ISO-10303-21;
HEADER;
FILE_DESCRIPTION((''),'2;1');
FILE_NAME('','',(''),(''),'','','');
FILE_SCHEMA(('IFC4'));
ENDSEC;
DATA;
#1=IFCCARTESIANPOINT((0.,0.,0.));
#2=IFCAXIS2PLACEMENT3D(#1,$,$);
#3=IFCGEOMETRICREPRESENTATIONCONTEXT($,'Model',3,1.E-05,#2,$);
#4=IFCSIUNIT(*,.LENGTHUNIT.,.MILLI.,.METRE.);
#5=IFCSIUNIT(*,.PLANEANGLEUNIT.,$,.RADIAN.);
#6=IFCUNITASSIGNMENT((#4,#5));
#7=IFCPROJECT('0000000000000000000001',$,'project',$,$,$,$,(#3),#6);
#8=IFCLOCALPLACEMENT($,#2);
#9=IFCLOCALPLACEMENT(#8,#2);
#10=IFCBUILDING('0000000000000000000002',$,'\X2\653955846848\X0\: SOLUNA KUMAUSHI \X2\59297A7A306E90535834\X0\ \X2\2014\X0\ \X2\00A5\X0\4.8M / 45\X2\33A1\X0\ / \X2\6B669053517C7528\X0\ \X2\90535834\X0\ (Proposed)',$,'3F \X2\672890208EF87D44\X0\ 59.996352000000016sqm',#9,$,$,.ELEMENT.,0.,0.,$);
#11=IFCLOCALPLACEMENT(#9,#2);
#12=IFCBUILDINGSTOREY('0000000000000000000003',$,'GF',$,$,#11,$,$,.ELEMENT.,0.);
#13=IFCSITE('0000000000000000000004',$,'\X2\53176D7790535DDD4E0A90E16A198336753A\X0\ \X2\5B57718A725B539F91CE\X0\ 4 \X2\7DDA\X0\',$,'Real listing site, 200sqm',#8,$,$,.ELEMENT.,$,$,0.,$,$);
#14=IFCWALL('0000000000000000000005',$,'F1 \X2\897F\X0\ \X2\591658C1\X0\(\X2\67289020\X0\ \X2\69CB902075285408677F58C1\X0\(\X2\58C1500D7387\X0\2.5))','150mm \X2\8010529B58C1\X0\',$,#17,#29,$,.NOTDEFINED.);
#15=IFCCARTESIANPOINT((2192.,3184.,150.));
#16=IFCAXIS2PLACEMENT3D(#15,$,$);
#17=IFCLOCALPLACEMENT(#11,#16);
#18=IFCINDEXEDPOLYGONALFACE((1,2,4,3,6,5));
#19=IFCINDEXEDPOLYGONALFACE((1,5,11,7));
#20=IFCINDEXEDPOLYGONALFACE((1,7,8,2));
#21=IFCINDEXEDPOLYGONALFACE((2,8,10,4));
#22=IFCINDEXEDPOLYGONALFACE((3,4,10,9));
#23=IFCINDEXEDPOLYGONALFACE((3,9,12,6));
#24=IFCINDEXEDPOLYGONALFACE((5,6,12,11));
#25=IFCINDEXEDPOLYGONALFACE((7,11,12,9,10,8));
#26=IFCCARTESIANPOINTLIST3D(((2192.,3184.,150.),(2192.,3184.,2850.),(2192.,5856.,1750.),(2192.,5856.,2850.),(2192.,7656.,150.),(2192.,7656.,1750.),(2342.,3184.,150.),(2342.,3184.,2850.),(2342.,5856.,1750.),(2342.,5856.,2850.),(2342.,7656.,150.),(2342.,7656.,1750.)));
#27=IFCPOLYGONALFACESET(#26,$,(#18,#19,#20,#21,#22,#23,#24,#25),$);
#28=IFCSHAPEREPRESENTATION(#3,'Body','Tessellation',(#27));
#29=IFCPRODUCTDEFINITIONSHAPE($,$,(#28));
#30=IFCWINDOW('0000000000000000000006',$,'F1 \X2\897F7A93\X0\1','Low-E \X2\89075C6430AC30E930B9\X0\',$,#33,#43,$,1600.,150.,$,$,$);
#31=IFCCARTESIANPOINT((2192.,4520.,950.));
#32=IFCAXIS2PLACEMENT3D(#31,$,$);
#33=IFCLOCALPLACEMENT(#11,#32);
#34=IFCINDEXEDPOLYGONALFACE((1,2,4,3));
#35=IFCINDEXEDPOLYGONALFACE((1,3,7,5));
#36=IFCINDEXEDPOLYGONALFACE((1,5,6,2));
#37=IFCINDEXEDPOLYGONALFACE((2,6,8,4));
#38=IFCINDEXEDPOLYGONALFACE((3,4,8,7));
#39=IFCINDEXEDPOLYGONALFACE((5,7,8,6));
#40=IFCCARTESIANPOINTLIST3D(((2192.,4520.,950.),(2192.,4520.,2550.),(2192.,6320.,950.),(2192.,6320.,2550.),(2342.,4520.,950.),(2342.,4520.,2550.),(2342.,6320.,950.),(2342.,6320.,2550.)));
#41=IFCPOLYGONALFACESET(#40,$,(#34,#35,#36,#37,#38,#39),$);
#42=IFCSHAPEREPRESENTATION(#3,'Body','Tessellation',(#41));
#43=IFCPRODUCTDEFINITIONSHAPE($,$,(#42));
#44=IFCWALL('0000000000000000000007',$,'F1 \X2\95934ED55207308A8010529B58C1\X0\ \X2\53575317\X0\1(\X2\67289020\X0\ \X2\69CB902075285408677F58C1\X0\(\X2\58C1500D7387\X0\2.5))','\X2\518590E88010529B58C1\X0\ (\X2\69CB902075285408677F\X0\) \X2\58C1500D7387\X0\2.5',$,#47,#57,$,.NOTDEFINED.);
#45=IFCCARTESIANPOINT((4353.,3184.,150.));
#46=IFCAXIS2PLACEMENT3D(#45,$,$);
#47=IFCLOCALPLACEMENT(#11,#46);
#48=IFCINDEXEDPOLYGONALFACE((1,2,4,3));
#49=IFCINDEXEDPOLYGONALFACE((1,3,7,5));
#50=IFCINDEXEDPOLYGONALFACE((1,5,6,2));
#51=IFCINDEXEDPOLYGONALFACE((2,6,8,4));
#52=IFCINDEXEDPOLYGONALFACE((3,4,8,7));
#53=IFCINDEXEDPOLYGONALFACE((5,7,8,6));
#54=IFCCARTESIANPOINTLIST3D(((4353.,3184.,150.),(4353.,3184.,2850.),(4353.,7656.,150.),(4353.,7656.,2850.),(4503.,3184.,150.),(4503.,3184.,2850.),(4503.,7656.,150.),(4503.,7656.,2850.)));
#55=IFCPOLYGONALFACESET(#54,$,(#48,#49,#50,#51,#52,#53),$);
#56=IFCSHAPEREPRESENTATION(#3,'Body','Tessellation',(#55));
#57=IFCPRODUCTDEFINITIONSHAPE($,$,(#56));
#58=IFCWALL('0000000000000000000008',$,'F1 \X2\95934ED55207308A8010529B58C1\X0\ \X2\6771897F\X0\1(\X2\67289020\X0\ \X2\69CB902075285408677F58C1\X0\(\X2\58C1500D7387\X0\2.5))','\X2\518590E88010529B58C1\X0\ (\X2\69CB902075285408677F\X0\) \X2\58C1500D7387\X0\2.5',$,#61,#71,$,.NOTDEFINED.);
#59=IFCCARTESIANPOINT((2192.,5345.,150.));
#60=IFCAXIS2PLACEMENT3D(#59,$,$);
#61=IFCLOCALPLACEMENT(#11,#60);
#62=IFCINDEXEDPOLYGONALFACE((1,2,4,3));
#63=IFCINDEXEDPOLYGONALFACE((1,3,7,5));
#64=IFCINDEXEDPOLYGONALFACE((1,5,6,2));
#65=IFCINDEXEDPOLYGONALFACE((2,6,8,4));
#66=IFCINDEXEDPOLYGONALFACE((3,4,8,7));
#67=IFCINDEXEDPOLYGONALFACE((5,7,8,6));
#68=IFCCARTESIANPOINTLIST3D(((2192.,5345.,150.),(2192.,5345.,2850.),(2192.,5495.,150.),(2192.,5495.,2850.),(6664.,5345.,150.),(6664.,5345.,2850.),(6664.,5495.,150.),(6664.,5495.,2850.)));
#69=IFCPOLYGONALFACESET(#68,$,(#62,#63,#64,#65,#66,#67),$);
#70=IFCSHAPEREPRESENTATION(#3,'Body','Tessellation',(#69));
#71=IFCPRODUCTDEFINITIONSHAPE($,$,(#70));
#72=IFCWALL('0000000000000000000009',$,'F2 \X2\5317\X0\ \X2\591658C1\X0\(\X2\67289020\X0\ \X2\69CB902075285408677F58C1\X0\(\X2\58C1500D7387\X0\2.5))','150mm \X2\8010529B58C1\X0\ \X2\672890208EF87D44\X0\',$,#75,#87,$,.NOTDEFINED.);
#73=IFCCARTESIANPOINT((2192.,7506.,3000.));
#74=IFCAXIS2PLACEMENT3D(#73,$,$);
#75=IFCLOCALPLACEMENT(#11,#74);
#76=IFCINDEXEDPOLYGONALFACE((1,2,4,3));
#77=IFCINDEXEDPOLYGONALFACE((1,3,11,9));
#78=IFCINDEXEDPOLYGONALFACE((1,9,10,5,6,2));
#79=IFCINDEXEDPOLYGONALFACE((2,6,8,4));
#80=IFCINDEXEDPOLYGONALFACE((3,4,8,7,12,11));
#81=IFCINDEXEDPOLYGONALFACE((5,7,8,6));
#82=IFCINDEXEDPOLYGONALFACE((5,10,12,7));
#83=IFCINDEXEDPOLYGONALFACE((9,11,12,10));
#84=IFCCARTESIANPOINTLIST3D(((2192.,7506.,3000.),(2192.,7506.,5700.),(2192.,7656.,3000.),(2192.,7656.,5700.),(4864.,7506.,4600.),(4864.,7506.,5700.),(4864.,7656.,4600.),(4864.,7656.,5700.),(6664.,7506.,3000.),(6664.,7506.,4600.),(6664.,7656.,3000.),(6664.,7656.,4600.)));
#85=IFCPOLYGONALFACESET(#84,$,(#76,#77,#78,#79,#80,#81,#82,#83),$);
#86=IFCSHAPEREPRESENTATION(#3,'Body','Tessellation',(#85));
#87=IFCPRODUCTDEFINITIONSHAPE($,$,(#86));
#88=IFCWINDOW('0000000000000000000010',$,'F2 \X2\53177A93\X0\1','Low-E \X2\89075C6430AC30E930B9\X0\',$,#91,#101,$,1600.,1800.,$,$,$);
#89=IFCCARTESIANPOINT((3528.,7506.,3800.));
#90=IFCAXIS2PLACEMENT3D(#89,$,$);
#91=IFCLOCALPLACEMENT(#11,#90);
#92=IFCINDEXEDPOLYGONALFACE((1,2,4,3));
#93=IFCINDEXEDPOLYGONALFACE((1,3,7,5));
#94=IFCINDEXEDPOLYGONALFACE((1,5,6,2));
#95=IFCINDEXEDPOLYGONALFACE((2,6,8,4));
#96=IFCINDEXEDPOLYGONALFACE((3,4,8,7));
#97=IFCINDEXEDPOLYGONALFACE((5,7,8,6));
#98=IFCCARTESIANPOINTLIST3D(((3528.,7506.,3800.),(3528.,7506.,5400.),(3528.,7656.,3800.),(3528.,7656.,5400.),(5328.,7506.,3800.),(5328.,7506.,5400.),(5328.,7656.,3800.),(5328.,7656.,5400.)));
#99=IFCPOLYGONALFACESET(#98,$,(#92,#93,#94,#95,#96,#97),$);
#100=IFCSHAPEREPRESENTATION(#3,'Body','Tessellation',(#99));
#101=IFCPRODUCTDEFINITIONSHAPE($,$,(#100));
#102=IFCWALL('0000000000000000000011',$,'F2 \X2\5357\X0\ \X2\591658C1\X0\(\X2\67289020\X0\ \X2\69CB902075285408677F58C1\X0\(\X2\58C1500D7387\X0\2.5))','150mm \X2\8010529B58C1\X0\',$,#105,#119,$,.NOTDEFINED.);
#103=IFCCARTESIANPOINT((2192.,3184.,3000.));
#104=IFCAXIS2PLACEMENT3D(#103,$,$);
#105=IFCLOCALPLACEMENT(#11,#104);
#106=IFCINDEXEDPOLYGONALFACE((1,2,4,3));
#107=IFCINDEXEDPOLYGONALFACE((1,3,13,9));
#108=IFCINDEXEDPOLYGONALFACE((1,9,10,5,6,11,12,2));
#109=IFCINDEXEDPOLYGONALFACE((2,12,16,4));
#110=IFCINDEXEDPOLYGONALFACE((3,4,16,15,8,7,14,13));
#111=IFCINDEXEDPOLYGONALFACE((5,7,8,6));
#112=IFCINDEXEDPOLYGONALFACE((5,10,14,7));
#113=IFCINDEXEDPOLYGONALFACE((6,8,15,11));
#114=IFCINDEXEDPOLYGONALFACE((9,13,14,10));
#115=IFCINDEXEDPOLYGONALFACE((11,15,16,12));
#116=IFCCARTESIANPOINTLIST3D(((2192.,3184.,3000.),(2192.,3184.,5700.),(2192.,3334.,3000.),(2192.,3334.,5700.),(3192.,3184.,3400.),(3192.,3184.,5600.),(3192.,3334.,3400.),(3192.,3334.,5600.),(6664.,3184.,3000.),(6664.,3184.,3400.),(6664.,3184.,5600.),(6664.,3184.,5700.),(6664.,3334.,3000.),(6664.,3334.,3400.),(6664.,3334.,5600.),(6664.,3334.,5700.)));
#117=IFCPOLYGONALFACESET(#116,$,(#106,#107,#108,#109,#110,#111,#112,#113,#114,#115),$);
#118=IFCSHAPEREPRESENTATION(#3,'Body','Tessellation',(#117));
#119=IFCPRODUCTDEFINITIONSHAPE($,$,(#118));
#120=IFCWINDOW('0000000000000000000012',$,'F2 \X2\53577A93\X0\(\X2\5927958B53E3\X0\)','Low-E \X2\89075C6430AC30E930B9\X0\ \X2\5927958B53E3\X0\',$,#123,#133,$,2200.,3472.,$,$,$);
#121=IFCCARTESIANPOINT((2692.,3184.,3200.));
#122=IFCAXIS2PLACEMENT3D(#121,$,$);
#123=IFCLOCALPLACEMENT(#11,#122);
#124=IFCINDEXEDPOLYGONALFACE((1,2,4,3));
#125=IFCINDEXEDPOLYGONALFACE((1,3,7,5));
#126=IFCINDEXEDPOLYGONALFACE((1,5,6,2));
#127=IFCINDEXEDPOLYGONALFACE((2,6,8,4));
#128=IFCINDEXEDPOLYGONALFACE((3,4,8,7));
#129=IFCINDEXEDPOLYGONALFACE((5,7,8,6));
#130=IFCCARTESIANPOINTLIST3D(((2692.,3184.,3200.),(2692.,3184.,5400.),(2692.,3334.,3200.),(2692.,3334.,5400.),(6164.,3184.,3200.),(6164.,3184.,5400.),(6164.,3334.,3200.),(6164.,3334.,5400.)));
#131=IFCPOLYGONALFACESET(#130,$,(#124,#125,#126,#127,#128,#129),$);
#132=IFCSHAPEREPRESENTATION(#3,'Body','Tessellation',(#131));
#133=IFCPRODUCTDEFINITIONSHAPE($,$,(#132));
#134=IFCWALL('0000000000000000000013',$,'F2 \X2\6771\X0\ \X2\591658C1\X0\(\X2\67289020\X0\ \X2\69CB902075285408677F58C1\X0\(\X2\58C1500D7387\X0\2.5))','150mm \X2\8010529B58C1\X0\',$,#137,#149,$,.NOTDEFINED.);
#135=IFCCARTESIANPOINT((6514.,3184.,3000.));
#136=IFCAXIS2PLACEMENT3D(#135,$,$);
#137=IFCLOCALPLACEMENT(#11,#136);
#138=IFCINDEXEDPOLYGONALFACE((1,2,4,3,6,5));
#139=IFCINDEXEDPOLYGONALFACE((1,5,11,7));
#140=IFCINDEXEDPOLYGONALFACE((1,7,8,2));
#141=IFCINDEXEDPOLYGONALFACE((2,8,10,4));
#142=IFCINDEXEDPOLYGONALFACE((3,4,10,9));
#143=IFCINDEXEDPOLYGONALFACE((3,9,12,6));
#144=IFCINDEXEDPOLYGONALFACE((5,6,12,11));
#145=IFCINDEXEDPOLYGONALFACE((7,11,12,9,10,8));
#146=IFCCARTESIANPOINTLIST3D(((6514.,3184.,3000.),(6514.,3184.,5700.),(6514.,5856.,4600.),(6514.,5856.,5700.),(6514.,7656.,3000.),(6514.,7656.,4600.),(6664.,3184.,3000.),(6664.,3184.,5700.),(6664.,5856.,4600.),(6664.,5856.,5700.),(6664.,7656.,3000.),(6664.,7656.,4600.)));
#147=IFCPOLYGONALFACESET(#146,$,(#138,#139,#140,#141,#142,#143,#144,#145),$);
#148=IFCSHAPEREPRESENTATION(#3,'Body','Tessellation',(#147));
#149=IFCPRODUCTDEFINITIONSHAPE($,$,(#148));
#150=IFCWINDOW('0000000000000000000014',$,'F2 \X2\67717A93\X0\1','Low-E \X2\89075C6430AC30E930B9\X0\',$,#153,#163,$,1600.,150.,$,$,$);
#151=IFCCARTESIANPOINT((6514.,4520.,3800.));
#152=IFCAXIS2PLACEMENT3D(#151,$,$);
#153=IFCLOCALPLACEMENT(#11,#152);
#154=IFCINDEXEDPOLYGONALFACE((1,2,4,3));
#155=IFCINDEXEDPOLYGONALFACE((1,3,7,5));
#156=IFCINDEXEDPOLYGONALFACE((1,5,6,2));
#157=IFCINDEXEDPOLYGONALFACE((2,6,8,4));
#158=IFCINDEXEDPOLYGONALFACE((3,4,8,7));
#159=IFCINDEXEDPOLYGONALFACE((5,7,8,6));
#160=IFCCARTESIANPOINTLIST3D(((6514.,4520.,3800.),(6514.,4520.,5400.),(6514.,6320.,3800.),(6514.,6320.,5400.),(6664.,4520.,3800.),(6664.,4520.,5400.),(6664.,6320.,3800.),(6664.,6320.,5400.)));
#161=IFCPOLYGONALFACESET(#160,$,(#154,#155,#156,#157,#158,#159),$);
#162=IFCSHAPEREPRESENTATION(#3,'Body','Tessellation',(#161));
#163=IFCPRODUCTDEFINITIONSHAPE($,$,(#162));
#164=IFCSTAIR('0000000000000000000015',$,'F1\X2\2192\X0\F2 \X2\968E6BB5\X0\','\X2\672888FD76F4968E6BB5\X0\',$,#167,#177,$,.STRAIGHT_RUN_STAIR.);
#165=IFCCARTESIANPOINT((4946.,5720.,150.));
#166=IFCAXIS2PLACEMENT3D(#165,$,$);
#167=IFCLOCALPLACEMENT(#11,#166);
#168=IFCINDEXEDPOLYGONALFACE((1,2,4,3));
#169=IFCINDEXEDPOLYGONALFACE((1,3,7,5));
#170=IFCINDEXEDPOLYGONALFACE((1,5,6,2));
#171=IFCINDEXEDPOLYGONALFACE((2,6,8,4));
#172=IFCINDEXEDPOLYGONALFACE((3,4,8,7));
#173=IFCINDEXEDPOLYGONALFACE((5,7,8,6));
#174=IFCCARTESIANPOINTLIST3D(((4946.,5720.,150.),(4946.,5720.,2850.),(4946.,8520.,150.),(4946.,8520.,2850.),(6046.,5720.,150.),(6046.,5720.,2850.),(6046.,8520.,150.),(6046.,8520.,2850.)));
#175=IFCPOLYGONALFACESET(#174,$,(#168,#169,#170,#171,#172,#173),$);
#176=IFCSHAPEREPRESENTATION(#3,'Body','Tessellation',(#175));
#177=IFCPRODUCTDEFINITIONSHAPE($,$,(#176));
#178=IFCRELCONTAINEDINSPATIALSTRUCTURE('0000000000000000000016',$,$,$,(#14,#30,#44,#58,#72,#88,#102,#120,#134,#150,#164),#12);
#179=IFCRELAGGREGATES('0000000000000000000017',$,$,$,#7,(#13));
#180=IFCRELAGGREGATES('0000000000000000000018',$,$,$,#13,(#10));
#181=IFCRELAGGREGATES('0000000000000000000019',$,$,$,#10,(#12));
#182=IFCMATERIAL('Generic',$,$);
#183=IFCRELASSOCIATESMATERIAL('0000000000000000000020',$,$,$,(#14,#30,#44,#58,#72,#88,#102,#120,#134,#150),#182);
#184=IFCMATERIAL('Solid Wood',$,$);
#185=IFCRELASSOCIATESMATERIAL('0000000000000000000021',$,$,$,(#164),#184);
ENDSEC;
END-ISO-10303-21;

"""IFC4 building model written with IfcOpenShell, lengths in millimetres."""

from ifc_helpers import new_model, si_unit, frame, frame_2d, origin, place, context, project, spatial, rectangle, extrude, material, element, fill, save


model = new_model("IFC4")

# Units and contexts
model_context = context("Model", 3, precision=1e-05, world=origin())
ifc_project = project(units=[si_unit("LENGTHUNIT", "METRE", prefix="MILLI"), si_unit("PLANEANGLEUNIT", "RADIAN")], contexts=[model_context])

# Site, building, storey
site_placement = place(None, origin())
site = spatial("IfcSite", under=ifc_project, at=site_placement, Name="北海道川上郡標茶町 字熊牛原野 4 線", ObjectType="Real listing site, 200sqm", CompositionType="ELEMENT", RefElevation=0.0)
building_placement = place(site_placement, origin())
building = spatial("IfcBuilding", under=site, at=building_placement, Name="改善案: SOLUNA KUMAUSHI 天空の道場 — ¥4.8M / 45㎡ / 武道兼用 道場 (Proposed)", ObjectType="3F 木造軸組 59.996352000000016sqm", CompositionType="ELEMENT", ElevationOfRefHeight=0.0, ElevationOfTerrain=0.0)
storey_placement = place(building_placement, origin())
storey = spatial("IfcBuildingStorey", under=building, at=storey_placement, Name="GF", CompositionType="ELEMENT", Elevation=0.0)

# Shared definitions
ifc_material_1 = material(Name="Generic")

# Shared definitions
ifc_material_2 = material(Name="Solid Wood")

# Wall, opening, window
wall_1_placement = place(storey_placement, frame((2192.0, 3184.0, 150.0)))
wall_1 = element("IfcWall", 1, at=wall_1_placement, inside=storey, material=ifc_material_1, Name="F1 西 外壁(木造 構造用合板壁(壁倍率2.5))", Description="150mm 耐力壁", PredefinedType="NOTDEFINED", context=model_context, shape_type="SweptSolid", body=[
    extrude(rectangle(XDim=150.0, YDim=4472.0, at=frame_2d((75.0, 2236.0))), frame((2192.0, 3184.0, 150.0)), (0.0, 0.0, 1.0), 2700.0),
])
opening_1_placement = place(storey_placement, frame((2192.0, 4520.0, 950.0)))
opening_1 = element("IfcOpeningElement", 2, at=opening_1_placement, cuts=wall_1, PredefinedType="NOTDEFINED", context=model_context, shape_type="SweptSolid", body=[
    extrude(rectangle(XDim=150.0, YDim=1800.0, at=frame_2d((75.0, 900.0))), frame((2192.0, 4520.0, 950.0)), (0.0, 0.0, 1.0), 1600.0),
])
window_1_placement = place(storey_placement, frame((2192.0, 4520.0, 950.0)))
window_1 = element("IfcWindow", 3, at=window_1_placement, inside=storey, material=ifc_material_1, Name="F1 西窓1", Description="Low-E 複層ガラス", OverallHeight=1600.0, OverallWidth=150.0, context=model_context, shape_type="SweptSolid", body=[
    extrude(rectangle(XDim=150.0, YDim=1800.0, at=frame_2d((75.0, 900.0))), frame((2192.0, 4520.0, 950.0)), (0.0, 0.0, 1.0), 1600.0),
])
fill(opening_1, window_1)

# Walls
wall_2_placement = place(storey_placement, frame((4353.0, 3184.0, 150.0)))
element("IfcWall", 4, at=wall_2_placement, inside=storey, material=ifc_material_1, Name="F1 間仕切り耐力壁 南北1(木造 構造用合板壁(壁倍率2.5))", Description="内部耐力壁 (構造用合板) 壁倍率2.5", PredefinedType="NOTDEFINED", context=model_context, shape_type="SweptSolid", body=[
    extrude(rectangle(XDim=150.0, YDim=4472.0, at=frame_2d((75.0, 2236.0))), frame((4353.0, 3184.0, 150.0)), (0.0, 0.0, 1.0), 2700.0),
])
wall_3_placement = place(storey_placement, frame((2192.0, 5345.0, 150.0)))
element("IfcWall", 5, at=wall_3_placement, inside=storey, material=ifc_material_1, Name="F1 間仕切り耐力壁 東西1(木造 構造用合板壁(壁倍率2.5))", Description="内部耐力壁 (構造用合板) 壁倍率2.5", PredefinedType="NOTDEFINED", context=model_context, shape_type="SweptSolid", body=[
    extrude(rectangle(XDim=4472.0, YDim=150.0, at=frame_2d((2236.0, 75.0))), frame((2192.0, 5345.0, 150.0)), (0.0, 0.0, 1.0), 2700.0),
])

# Walls, openings, windows
wall_4_placement = place(storey_placement, frame((2192.0, 7506.0, 3000.0)))
wall_4 = element("IfcWall", 6, at=wall_4_placement, inside=storey, material=ifc_material_1, Name="F2 北 外壁(木造 構造用合板壁(壁倍率2.5))", Description="150mm 耐力壁 木造軸組", PredefinedType="NOTDEFINED", context=model_context, shape_type="SweptSolid", body=[
    extrude(rectangle(XDim=4472.0, YDim=150.0, at=frame_2d((2236.0, 75.0))), frame((2192.0, 7506.0, 3000.0)), (0.0, 0.0, 1.0), 2700.0),
])
opening_2_placement = place(storey_placement, frame((3528.0, 7506.0, 3800.0)))
opening_2 = element("IfcOpeningElement", 7, at=opening_2_placement, cuts=wall_4, PredefinedType="NOTDEFINED", context=model_context, shape_type="SweptSolid", body=[
    extrude(rectangle(XDim=1800.0, YDim=150.0, at=frame_2d((900.0, 75.0))), frame((3528.0, 7506.0, 3800.0)), (0.0, 0.0, 1.0), 1600.0),
])
window_2_placement = place(storey_placement, frame((3528.0, 7506.0, 3800.0)))
window_2 = element("IfcWindow", 8, at=window_2_placement, inside=storey, material=ifc_material_1, Name="F2 北窓1", Description="Low-E 複層ガラス", OverallHeight=1600.0, OverallWidth=1800.0, context=model_context, shape_type="SweptSolid", body=[
    extrude(rectangle(XDim=1800.0, YDim=150.0, at=frame_2d((900.0, 75.0))), frame((3528.0, 7506.0, 3800.0)), (0.0, 0.0, 1.0), 1600.0),
])
fill(opening_2, window_2)
wall_5_placement = place(storey_placement, frame((2192.0, 3184.0, 3000.0)))
wall_5 = element("IfcWall", 9, at=wall_5_placement, inside=storey, material=ifc_material_1, Name="F2 南 外壁(木造 構造用合板壁(壁倍率2.5))", Description="150mm 耐力壁", PredefinedType="NOTDEFINED", context=model_context, shape_type="SweptSolid", body=[
    extrude(rectangle(XDim=4472.0, YDim=150.0, at=frame_2d((2236.0, 75.0))), frame((2192.0, 3184.0, 3000.0)), (0.0, 0.0, 1.0), 2700.0),
])
opening_3_placement = place(storey_placement, frame((2692.0, 3184.0, 3200.0)))
opening_3 = element("IfcOpeningElement", 10, at=opening_3_placement, cuts=wall_5, PredefinedType="NOTDEFINED", context=model_context, shape_type="SweptSolid", body=[
    extrude(rectangle(XDim=3472.0, YDim=150.0, at=frame_2d((1736.0, 75.0))), frame((2692.0, 3184.0, 3200.0)), (0.0, 0.0, 1.0), 2200.0),
])
window_3_placement = place(storey_placement, frame((2692.0, 3184.0, 3200.0)))
window_3 = element("IfcWindow", 11, at=window_3_placement, inside=storey, material=ifc_material_1, Name="F2 南窓(大開口)", Description="Low-E 複層ガラス 大開口", OverallHeight=2200.0, OverallWidth=3472.0, context=model_context, shape_type="SweptSolid", body=[
    extrude(rectangle(XDim=3472.0, YDim=150.0, at=frame_2d((1736.0, 75.0))), frame((2692.0, 3184.0, 3200.0)), (0.0, 0.0, 1.0), 2200.0),
])
fill(opening_3, window_3)
wall_6_placement = place(storey_placement, frame((6514.0, 3184.0, 3000.0)))
wall_6 = element("IfcWall", 12, at=wall_6_placement, inside=storey, material=ifc_material_1, Name="F2 東 外壁(木造 構造用合板壁(壁倍率2.5))", Description="150mm 耐力壁", PredefinedType="NOTDEFINED", context=model_context, shape_type="SweptSolid", body=[
    extrude(rectangle(XDim=150.0, YDim=4472.0, at=frame_2d((75.0, 2236.0))), frame((6514.0, 3184.0, 3000.0)), (0.0, 0.0, 1.0), 2700.0),
])
opening_4_placement = place(storey_placement, frame((6514.0, 4520.0, 3800.0)))
opening_4 = element("IfcOpeningElement", 13, at=opening_4_placement, cuts=wall_6, PredefinedType="NOTDEFINED", context=model_context, shape_type="SweptSolid", body=[
    extrude(rectangle(XDim=150.0, YDim=1800.0, at=frame_2d((75.0, 900.0))), frame((6514.0, 4520.0, 3800.0)), (0.0, 0.0, 1.0), 1600.0),
])
window_4_placement = place(storey_placement, frame((6514.0, 4520.0, 3800.0)))
window_4 = element("IfcWindow", 14, at=window_4_placement, inside=storey, material=ifc_material_1, Name="F2 東窓1", Description="Low-E 複層ガラス", OverallHeight=1600.0, OverallWidth=150.0, context=model_context, shape_type="SweptSolid", body=[
    extrude(rectangle(XDim=150.0, YDim=1800.0, at=frame_2d((75.0, 900.0))), frame((6514.0, 4520.0, 3800.0)), (0.0, 0.0, 1.0), 1600.0),
])
fill(opening_4, window_4)

# Stair
stair_placement = place(storey_placement, frame((4946.0, 5720.0, 150.0)))
element("IfcStair", 15, at=stair_placement, inside=storey, material=ifc_material_2, Name="F1→F2 階段", Description="木製直階段", PredefinedType="STRAIGHT_RUN_STAIR", context=model_context, shape_type="SweptSolid", body=[
    extrude(rectangle(XDim=1100.0, YDim=2800.0, at=frame_2d((550.0, 1400.0))), frame((4946.0, 5720.0, 150.0)), (0.0, 0.0, 1.0), 2700.0),
])

save(model, "model.ifc")
